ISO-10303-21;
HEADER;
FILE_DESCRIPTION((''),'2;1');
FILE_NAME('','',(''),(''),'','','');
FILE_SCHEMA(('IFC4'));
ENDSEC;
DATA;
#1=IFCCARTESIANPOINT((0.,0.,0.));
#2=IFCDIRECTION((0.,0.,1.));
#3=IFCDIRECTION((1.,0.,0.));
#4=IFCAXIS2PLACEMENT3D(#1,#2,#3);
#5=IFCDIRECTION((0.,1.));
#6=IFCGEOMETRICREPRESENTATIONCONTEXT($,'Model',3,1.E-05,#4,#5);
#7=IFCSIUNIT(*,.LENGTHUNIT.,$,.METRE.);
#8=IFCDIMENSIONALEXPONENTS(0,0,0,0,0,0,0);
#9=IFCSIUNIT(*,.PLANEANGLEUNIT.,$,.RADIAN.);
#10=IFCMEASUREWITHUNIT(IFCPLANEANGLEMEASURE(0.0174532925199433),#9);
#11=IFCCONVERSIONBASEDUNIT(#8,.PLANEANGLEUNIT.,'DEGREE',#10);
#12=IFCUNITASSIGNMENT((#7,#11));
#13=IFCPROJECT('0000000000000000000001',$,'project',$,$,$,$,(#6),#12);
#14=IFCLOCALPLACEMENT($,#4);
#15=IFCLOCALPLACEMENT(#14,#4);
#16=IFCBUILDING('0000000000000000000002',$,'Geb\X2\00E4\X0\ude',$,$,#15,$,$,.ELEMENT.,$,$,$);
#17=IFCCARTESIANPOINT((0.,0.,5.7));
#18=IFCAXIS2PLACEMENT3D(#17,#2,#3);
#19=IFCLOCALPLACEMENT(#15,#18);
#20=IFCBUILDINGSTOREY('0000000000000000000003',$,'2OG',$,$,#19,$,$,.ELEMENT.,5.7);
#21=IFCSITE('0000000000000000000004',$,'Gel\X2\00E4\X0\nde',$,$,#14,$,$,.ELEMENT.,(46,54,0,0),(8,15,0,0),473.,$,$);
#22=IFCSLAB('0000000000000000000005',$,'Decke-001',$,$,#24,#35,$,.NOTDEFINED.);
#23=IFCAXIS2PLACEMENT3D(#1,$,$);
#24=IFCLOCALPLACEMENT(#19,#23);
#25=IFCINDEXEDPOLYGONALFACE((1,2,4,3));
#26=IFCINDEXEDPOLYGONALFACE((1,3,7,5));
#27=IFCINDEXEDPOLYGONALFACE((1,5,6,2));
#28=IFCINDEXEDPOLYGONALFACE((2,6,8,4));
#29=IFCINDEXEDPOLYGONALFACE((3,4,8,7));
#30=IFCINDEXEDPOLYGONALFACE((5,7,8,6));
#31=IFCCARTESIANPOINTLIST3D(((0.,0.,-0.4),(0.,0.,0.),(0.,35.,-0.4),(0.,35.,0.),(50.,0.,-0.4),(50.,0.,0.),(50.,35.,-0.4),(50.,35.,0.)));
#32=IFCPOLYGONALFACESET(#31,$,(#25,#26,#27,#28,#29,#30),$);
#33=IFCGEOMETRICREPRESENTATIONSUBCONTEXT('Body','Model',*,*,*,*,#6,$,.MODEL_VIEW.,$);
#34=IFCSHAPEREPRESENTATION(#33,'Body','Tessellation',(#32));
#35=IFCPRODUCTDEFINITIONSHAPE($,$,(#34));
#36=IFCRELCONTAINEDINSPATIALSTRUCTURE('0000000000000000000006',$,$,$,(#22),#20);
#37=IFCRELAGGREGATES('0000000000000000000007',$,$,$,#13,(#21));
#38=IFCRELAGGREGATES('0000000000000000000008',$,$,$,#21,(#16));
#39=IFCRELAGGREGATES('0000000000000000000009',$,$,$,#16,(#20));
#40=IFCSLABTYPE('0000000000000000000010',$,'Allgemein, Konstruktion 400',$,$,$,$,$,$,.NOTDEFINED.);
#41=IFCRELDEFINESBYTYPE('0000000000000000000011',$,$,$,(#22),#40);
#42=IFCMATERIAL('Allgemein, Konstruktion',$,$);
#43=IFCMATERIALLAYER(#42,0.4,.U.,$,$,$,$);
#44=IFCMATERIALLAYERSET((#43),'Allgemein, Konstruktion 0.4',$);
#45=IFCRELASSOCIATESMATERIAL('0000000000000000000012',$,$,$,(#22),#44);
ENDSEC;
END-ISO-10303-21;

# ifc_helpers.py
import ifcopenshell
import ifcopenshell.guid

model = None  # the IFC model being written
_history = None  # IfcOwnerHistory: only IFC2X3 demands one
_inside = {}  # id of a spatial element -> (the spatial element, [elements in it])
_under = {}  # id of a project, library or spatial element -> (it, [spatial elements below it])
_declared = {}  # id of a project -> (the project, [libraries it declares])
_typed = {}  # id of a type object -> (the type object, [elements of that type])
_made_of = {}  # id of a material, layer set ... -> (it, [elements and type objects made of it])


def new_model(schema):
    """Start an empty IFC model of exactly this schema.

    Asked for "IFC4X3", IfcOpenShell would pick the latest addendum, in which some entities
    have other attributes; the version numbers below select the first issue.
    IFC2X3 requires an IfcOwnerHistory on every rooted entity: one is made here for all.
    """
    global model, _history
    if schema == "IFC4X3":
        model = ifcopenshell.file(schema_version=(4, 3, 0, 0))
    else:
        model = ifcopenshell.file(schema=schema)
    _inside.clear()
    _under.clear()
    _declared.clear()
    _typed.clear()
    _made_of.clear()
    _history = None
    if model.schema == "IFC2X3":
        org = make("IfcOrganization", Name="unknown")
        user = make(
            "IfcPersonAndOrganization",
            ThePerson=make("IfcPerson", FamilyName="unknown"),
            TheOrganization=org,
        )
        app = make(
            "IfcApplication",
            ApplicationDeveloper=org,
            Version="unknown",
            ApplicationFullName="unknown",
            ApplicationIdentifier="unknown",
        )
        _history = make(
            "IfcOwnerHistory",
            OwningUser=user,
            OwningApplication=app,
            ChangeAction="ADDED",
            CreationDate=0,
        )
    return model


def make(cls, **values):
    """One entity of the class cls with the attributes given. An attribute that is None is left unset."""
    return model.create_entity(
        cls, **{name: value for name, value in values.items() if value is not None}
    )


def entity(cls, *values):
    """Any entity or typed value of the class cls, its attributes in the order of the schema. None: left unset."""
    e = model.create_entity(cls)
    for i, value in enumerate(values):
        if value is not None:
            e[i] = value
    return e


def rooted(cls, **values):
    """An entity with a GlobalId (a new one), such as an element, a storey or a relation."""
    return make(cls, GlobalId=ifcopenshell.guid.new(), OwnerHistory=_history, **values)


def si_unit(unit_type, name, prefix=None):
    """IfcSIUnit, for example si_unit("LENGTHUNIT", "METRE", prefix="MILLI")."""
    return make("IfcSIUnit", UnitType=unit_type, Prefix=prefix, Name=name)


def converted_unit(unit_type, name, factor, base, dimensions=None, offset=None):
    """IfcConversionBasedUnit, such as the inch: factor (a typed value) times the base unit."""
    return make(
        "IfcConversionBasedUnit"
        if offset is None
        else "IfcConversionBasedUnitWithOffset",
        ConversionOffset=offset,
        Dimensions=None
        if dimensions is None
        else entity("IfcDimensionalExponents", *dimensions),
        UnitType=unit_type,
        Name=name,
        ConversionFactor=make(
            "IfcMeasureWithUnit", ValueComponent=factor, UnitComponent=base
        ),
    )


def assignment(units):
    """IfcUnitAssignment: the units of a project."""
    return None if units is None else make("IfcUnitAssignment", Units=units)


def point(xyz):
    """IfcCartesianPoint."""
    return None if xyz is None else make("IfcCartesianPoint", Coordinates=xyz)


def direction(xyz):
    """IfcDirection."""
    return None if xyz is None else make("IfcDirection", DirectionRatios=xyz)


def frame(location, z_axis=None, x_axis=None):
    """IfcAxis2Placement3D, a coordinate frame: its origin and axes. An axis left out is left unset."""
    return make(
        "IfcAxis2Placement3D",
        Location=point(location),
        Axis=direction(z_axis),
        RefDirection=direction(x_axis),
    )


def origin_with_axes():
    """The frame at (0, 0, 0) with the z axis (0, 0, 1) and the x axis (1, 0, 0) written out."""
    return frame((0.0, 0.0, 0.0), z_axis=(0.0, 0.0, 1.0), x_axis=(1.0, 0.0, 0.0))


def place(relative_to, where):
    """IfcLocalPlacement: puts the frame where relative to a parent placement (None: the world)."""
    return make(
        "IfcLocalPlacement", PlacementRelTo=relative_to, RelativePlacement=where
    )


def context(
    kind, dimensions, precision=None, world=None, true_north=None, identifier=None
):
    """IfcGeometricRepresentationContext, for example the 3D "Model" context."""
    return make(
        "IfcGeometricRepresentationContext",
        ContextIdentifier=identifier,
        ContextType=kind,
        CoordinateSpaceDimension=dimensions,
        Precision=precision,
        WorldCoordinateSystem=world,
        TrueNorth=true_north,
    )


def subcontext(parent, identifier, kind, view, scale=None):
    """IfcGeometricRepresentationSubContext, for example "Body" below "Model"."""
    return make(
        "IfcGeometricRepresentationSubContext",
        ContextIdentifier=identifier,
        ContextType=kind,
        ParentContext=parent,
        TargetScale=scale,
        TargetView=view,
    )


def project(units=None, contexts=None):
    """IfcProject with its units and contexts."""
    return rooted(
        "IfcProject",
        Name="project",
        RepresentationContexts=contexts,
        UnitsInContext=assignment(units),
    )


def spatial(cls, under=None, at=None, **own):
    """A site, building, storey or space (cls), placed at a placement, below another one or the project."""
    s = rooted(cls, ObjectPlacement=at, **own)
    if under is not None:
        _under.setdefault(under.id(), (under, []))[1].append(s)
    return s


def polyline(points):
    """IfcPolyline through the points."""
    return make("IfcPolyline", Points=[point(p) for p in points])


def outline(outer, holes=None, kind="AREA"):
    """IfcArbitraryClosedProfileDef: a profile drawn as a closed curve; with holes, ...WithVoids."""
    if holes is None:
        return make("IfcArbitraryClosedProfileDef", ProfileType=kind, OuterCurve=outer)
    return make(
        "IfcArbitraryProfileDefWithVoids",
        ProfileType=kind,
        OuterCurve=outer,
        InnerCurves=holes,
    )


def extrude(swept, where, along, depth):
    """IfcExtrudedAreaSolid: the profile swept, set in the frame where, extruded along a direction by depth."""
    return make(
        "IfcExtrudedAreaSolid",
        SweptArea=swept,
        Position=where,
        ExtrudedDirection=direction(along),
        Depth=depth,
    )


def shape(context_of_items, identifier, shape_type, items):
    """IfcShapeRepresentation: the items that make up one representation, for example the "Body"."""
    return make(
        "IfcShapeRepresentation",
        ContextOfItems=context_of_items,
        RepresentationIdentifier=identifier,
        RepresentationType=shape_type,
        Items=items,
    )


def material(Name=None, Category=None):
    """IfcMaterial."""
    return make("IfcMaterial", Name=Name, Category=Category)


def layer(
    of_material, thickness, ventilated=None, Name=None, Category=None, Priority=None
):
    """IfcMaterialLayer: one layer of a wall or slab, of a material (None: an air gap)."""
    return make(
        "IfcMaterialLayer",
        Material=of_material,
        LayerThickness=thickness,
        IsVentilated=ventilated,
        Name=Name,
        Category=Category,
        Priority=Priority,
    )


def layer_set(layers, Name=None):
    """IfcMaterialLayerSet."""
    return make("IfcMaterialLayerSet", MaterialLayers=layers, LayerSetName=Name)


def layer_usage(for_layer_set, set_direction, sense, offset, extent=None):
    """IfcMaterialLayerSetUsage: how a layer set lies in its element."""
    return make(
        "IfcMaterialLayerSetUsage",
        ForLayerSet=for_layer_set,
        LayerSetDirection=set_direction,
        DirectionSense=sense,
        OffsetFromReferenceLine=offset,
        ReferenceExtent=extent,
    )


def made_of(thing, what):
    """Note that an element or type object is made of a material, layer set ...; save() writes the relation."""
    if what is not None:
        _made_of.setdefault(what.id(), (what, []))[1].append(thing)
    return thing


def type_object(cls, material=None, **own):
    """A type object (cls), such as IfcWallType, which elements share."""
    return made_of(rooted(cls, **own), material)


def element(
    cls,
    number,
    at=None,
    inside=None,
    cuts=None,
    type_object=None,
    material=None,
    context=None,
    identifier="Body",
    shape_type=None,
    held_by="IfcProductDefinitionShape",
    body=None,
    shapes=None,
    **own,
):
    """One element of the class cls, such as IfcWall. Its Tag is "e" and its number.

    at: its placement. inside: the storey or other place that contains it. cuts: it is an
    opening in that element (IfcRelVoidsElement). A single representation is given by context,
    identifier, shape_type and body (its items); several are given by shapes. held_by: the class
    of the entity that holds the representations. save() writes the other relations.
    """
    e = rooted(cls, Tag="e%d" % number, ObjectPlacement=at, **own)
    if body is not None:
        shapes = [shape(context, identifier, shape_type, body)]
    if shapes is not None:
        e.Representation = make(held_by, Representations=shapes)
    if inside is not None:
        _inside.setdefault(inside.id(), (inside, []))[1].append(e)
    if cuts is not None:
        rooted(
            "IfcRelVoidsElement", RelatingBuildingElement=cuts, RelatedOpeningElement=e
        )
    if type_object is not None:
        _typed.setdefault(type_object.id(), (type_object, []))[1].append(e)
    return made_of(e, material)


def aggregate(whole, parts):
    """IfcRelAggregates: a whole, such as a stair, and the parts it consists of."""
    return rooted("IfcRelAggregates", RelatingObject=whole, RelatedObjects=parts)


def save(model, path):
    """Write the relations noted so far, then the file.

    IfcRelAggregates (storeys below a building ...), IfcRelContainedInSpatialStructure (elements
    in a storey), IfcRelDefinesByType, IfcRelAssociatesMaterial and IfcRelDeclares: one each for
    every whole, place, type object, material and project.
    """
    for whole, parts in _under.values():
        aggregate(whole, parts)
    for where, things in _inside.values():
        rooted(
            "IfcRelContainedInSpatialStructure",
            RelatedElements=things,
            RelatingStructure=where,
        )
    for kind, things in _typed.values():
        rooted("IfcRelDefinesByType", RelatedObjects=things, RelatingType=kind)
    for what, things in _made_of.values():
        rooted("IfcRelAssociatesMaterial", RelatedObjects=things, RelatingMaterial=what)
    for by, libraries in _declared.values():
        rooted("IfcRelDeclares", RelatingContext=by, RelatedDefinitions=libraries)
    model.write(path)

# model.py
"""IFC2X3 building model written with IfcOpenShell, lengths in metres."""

from ifc_helpers import new_model, entity, si_unit, converted_unit, direction, frame, origin_with_axes, place, context, subcontext, project, spatial, polyline, outline, extrude, material, layer, layer_set, layer_usage, type_object, element, save


model = new_model("IFC2X3")

# Units and contexts
model_context = context("Model", 3, precision=1e-05, world=origin_with_axes(), true_north=direction((0.0, 1.0)))
body_context = subcontext(model_context, "Body", "Model", "MODEL_VIEW")
ifc_project = project(units=[si_unit("LENGTHUNIT", "METRE"), converted_unit("PLANEANGLEUNIT", "DEGREE", entity("IfcPlaneAngleMeasure", 0.0174532925199433), si_unit("PLANEANGLEUNIT", "RADIAN"), dimensions=[0, 0, 0, 0, 0, 0, 0])], contexts=[model_context])

# Site, building, storey
site_placement = place(None, origin_with_axes())
site = spatial("IfcSite", under=ifc_project, at=site_placement, Name="Gelände", CompositionType="ELEMENT", RefLatitude=(46, 54, 0, 0), RefLongitude=(8, 15, 0, 0), RefElevation=473.0)
building_placement = place(site_placement, origin_with_axes())
building = spatial("IfcBuilding", under=site, at=building_placement, Name="Gebäude", CompositionType="ELEMENT")
storey_placement = place(building_placement, frame((0.0, 0.0, 5.7), z_axis=(0.0, 0.0, 1.0), x_axis=(1.0, 0.0, 0.0)))
storey = spatial("IfcBuildingStorey", under=building, at=storey_placement, Name="2OG", CompositionType="ELEMENT", Elevation=5.7)

# Slab
ifc_material = material(Name="Allgemein, Konstruktion")
ifc_layer = layer(ifc_material, 0.4, ventilated="UNKNOWN")
ifc_layer_set = layer_set([ifc_layer], Name="Allgemein, Konstruktion 0.4")
ifc_layer_usage = layer_usage(ifc_layer_set, "AXIS3", "NEGATIVE", 0.4)
slab_type = type_object("IfcSlabType", Name="Allgemein, Konstruktion 400", PredefinedType="NOTDEFINED")
slab_placement = place(storey_placement, origin_with_axes())
element("IfcSlab", 1, at=slab_placement, inside=storey, type_object=slab_type, material=ifc_layer_usage, Name="Decke-001", PredefinedType="NOTDEFINED", context=body_context, shape_type="SweptSolid", body=[
    extrude(outline(polyline([(0.0, 0.0), (50.0, 0.0), (50.0, 35.0), (0.0, 35.0), (0.0, 0.0)])), frame((0.0, 0.0, -0.4), z_axis=(0.0, 0.0, 1.0), x_axis=(1.0, 0.0, 0.0)), (0.0, 0.0, 1.0), 0.4),
])

save(model, "model.ifc")
